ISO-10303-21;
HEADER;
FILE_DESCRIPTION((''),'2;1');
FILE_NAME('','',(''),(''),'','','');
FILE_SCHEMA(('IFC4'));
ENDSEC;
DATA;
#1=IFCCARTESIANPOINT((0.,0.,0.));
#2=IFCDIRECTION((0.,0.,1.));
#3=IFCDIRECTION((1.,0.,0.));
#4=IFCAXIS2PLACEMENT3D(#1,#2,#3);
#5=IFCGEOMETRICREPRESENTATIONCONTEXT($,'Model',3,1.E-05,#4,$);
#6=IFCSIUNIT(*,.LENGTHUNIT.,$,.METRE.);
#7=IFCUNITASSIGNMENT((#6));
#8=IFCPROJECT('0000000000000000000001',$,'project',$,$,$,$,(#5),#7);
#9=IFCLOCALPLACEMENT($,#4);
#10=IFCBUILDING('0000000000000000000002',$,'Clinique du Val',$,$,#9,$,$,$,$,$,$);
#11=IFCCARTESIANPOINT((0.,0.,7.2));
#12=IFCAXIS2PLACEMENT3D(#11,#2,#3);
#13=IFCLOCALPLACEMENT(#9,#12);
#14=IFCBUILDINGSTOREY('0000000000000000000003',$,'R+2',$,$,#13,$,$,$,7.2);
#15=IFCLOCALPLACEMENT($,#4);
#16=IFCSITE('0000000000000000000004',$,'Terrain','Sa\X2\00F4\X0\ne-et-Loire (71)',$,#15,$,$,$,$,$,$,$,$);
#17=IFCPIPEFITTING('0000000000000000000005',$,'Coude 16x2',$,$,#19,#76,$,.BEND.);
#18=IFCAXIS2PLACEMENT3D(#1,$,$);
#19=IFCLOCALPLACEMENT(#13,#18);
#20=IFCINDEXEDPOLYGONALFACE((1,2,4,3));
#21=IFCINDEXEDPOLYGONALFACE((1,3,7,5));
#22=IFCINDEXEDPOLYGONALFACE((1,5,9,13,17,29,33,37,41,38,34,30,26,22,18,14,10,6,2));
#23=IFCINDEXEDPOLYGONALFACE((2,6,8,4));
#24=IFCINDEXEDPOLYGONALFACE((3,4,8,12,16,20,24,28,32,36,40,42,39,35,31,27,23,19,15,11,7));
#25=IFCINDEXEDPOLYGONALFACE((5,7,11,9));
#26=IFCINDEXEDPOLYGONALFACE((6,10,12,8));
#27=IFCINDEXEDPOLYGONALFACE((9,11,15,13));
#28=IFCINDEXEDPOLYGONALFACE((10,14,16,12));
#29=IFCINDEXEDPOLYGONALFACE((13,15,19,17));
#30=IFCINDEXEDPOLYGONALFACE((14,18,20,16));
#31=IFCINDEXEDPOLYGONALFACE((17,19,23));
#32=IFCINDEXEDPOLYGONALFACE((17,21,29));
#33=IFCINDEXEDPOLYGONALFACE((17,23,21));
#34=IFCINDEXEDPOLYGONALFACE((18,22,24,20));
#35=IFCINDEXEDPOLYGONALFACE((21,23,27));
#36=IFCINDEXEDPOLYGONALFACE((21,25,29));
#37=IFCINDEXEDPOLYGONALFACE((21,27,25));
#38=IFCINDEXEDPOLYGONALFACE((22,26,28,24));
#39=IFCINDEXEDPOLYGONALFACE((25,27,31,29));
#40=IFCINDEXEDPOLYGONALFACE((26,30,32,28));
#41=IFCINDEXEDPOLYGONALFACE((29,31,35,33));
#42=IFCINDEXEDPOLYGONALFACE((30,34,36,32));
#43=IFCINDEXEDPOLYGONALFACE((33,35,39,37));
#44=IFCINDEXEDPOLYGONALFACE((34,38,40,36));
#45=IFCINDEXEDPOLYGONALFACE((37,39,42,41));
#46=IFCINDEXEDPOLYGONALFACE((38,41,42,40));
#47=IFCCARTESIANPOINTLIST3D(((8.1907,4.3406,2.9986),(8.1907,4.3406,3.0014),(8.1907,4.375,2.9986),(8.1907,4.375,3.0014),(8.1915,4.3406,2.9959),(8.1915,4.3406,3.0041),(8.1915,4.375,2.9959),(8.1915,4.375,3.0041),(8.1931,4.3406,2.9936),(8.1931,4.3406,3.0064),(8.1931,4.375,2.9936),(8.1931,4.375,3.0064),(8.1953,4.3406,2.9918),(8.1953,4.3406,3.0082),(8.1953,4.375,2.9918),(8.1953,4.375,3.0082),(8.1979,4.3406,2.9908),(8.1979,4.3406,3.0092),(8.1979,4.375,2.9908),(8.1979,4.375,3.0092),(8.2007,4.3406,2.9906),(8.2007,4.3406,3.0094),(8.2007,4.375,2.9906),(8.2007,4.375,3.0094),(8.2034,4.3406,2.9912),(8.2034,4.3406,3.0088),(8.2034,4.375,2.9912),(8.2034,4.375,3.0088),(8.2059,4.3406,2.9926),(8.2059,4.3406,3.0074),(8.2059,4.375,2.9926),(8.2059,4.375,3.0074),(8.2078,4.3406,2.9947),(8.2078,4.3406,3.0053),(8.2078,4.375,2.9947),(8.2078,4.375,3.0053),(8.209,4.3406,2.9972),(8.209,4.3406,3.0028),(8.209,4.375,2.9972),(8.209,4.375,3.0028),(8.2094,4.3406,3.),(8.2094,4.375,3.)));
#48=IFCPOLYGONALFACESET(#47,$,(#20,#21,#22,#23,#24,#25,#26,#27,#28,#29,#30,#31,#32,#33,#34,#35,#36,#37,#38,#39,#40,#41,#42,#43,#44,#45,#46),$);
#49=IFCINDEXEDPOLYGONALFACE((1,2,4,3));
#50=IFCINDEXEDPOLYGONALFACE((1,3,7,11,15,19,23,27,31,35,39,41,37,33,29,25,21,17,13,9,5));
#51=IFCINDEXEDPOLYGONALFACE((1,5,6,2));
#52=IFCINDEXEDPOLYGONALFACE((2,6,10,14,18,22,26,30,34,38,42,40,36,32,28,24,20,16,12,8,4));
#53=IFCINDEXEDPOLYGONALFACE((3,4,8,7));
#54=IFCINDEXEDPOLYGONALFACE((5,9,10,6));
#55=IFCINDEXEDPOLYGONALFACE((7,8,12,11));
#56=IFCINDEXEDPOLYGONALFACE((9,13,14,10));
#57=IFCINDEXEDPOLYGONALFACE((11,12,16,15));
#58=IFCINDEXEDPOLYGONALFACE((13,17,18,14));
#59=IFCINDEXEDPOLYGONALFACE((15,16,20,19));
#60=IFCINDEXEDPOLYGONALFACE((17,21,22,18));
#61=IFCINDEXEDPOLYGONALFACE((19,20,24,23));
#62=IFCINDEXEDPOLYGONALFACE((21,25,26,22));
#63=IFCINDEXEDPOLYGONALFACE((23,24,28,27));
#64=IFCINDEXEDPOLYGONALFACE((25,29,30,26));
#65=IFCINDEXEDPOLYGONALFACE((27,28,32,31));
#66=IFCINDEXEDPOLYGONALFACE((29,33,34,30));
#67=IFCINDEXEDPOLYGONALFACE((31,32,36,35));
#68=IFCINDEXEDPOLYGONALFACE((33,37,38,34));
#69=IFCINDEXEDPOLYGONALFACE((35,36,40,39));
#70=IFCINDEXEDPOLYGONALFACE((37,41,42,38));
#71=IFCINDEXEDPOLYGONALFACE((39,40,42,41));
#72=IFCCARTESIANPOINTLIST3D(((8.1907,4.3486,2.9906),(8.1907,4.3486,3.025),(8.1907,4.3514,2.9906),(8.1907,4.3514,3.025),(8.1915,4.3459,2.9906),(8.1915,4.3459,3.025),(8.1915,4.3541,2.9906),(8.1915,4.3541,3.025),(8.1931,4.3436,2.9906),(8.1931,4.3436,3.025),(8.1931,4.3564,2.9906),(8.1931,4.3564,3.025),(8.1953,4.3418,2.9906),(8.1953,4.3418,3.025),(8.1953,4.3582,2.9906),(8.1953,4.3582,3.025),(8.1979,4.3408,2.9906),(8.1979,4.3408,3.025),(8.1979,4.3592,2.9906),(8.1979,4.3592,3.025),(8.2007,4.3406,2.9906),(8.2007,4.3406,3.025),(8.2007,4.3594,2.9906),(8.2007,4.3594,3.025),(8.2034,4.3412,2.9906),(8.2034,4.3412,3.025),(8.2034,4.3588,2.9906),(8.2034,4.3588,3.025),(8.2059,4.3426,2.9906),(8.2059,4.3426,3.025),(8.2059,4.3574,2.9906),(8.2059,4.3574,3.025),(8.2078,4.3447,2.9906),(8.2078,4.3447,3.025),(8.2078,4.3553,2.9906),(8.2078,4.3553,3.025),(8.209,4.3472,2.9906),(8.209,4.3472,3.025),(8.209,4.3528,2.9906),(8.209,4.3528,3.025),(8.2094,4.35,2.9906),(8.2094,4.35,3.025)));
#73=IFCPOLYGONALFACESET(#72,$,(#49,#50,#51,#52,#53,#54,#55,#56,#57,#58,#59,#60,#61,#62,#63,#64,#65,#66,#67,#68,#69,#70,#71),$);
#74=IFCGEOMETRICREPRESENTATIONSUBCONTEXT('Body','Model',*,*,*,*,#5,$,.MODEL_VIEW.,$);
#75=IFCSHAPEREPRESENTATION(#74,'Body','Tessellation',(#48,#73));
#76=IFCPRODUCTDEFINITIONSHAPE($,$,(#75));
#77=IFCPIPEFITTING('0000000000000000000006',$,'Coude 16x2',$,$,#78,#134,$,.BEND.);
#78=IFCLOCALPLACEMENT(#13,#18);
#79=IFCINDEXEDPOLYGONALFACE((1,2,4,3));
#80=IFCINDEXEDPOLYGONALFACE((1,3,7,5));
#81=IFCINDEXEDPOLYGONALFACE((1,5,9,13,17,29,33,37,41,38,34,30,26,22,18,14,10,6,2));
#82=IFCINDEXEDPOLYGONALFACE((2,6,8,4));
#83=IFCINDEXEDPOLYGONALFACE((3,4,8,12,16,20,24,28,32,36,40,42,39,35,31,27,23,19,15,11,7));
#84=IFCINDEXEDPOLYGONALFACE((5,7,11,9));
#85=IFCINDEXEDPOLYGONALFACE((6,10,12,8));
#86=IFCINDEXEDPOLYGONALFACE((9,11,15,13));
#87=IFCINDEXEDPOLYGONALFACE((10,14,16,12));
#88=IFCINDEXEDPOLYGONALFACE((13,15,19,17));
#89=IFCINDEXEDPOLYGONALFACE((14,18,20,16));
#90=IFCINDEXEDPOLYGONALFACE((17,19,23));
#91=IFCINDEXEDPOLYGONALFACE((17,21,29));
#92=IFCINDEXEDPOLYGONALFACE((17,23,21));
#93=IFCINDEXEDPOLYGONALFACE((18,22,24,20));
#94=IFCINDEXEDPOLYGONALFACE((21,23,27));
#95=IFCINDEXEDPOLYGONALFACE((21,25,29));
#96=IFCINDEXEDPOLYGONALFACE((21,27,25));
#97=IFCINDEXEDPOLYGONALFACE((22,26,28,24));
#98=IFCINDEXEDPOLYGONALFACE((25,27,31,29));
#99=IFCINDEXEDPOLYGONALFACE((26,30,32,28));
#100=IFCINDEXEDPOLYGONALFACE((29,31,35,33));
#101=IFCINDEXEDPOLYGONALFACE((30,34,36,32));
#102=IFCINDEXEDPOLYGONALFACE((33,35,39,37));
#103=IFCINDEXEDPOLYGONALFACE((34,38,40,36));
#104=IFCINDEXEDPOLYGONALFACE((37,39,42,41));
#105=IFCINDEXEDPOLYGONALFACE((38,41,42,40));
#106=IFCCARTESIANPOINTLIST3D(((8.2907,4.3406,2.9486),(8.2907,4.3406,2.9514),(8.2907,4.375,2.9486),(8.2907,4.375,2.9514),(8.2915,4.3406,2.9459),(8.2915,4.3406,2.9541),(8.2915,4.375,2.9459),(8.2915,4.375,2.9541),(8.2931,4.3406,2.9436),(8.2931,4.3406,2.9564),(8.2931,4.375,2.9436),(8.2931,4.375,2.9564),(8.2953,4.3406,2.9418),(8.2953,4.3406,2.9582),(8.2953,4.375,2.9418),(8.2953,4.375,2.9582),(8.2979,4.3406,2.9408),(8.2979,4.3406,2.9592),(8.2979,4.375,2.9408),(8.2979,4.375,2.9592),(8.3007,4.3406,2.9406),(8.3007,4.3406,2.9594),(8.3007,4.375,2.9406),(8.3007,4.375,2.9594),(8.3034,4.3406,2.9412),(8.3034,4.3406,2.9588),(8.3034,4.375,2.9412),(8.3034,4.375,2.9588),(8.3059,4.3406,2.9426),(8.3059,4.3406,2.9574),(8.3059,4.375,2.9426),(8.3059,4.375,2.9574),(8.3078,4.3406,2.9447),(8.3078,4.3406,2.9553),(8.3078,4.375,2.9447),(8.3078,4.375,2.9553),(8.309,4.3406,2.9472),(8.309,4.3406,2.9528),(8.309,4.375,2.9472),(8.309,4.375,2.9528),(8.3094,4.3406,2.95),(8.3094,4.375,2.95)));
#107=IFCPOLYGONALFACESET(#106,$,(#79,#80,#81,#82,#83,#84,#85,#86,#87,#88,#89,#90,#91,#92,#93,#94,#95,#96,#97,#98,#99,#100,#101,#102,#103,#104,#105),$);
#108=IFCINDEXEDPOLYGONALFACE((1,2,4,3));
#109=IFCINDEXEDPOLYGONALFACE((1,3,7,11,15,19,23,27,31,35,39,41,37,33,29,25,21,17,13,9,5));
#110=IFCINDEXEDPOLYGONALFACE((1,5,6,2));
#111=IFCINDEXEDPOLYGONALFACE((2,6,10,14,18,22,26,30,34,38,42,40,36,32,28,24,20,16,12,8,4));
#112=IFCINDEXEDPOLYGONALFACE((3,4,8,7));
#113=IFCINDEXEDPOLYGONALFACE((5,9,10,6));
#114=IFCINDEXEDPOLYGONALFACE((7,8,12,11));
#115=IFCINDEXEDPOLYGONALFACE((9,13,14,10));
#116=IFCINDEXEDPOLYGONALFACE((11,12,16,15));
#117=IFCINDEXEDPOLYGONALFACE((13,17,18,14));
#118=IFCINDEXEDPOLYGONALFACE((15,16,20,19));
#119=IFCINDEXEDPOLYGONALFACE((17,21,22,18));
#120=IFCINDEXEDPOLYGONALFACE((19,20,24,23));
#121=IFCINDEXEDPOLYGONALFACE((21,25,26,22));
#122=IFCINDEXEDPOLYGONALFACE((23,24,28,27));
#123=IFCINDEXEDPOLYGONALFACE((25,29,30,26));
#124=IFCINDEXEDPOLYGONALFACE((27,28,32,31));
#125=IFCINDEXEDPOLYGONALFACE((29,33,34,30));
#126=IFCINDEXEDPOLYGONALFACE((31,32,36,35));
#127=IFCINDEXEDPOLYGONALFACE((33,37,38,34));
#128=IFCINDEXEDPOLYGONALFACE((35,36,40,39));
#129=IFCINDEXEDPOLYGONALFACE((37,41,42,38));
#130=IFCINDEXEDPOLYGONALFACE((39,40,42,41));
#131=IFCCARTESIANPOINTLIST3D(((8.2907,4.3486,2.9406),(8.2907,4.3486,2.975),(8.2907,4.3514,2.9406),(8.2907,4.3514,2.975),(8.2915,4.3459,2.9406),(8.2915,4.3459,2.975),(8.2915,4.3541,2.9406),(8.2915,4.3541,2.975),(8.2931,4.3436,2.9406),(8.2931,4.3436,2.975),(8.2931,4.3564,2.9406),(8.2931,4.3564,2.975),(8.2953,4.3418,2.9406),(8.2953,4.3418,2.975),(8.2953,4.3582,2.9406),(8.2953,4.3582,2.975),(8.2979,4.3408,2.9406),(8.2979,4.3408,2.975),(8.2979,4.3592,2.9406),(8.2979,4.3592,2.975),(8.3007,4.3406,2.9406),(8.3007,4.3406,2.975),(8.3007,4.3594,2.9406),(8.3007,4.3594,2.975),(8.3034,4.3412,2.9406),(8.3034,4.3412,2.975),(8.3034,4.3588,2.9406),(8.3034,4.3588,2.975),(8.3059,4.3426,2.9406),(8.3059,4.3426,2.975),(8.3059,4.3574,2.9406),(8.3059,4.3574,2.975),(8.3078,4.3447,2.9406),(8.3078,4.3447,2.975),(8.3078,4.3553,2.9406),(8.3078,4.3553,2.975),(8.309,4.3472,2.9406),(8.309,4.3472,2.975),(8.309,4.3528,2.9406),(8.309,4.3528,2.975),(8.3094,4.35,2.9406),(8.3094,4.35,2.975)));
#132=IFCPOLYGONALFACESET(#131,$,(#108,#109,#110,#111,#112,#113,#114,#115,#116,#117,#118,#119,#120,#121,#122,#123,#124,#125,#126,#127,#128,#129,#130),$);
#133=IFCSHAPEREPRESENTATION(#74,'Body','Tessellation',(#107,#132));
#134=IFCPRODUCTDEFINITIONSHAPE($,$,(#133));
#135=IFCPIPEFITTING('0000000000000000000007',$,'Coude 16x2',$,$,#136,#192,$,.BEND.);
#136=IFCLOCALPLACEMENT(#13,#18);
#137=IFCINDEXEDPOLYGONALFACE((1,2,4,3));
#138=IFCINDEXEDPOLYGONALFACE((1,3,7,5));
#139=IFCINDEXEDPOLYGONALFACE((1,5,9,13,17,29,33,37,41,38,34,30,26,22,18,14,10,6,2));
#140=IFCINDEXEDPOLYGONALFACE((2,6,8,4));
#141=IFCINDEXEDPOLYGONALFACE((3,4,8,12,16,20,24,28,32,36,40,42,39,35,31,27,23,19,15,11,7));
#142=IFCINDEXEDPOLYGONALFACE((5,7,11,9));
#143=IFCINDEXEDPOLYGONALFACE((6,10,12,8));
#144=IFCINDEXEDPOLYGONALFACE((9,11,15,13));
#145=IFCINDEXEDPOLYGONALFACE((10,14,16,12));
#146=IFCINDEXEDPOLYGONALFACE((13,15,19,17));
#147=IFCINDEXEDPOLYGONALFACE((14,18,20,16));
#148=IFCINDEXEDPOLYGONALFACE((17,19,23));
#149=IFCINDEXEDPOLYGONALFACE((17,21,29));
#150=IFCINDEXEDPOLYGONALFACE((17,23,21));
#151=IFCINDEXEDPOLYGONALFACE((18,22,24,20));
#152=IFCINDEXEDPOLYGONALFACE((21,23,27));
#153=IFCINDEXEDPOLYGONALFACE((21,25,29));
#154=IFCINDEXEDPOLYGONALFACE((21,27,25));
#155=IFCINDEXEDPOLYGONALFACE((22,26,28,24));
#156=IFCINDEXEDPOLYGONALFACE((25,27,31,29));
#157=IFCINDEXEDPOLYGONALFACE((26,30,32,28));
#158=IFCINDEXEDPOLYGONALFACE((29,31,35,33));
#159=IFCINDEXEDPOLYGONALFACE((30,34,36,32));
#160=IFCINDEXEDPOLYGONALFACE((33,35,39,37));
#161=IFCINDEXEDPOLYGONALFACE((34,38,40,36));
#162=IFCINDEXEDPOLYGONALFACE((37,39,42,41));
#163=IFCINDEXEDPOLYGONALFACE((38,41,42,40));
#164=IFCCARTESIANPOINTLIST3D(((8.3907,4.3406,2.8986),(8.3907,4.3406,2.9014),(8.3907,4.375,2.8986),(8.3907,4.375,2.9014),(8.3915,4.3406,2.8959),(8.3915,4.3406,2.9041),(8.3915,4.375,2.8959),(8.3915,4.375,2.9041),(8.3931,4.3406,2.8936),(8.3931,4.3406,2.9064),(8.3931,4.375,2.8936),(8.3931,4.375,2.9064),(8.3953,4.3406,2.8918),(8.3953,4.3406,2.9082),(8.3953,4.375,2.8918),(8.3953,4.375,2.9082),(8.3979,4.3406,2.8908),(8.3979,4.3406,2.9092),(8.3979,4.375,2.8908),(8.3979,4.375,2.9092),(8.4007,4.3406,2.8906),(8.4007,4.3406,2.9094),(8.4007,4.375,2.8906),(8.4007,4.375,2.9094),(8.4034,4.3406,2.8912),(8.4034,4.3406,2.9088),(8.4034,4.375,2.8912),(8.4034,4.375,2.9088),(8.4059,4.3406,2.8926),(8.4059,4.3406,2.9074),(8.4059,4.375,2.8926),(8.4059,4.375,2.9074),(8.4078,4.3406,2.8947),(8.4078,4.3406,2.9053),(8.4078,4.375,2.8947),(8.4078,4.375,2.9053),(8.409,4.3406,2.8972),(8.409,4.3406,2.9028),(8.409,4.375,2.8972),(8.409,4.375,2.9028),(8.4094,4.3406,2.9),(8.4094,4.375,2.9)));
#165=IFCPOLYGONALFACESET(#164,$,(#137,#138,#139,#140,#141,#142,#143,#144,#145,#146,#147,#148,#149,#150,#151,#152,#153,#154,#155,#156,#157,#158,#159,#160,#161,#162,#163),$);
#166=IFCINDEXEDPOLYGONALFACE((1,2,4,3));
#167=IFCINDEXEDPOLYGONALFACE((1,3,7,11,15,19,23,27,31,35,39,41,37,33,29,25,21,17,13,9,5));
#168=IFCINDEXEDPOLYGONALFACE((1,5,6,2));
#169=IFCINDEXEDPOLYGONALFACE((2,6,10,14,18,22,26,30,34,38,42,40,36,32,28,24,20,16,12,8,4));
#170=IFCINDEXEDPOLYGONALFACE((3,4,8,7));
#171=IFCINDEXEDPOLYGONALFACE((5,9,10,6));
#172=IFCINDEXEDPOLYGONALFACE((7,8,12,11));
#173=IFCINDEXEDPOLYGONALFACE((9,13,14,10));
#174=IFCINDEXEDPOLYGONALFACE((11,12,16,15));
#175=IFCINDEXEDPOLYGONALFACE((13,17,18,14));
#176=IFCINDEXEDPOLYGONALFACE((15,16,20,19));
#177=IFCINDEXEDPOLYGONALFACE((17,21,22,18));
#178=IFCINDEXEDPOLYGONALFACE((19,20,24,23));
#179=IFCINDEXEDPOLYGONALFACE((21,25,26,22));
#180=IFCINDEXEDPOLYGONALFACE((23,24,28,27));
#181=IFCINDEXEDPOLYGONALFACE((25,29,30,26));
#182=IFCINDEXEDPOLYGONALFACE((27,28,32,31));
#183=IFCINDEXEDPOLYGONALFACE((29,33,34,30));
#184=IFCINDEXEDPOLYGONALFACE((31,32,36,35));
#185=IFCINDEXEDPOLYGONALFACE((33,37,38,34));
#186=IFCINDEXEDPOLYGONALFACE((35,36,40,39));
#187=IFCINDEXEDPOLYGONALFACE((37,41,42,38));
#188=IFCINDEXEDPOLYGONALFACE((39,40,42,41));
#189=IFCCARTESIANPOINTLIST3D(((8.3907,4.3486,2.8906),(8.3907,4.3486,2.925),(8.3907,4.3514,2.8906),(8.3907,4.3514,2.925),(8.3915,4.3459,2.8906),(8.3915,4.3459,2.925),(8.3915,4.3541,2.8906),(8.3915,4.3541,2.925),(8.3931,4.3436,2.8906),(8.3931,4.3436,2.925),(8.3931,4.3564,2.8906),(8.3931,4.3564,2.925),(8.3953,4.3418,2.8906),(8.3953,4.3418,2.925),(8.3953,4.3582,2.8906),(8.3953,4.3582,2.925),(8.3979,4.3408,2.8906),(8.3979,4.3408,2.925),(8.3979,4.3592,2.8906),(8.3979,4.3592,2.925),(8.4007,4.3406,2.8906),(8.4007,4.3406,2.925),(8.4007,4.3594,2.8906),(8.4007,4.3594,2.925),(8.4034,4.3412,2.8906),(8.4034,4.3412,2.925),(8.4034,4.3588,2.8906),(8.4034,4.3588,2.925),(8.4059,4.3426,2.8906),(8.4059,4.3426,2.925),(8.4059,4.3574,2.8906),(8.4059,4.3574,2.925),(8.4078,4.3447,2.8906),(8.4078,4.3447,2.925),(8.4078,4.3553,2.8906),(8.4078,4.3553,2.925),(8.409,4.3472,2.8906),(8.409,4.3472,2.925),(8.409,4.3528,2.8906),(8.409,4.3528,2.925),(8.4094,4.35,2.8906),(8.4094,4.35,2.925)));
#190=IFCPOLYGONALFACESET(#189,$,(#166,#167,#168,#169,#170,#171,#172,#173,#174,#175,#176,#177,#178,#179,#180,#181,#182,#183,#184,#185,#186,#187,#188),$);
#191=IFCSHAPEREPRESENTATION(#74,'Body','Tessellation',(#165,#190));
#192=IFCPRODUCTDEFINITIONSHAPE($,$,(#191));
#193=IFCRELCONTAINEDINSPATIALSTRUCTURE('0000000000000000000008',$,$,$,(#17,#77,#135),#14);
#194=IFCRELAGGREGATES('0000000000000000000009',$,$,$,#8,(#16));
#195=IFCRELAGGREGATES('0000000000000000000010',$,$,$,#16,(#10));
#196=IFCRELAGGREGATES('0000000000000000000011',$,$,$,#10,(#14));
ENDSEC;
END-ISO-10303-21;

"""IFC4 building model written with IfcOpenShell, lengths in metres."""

from ifc_helpers import new_model, si_unit, frame, origin_with_axes, place, context, subcontext, project, spatial, circle, extrude, element, save


model = new_model("IFC4")

# Units and contexts
model_context = context("Model", 3, precision=1e-05, world=origin_with_axes())
body_context = subcontext(model_context, "Body", "Model", "MODEL_VIEW")
ifc_project = project(units=[si_unit("LENGTHUNIT", "METRE")], contexts=[model_context])

# Site, building, storey
site_placement = place(None, origin_with_axes())
site = spatial("IfcSite", under=ifc_project, at=site_placement, Name="Terrain", Description="Saône-et-Loire (71)")
building_placement = place(None, origin_with_axes())
building = spatial("IfcBuilding", under=site, at=building_placement, Name="Clinique du Val")
storey_placement = place(building_placement, frame((0.0, 0.0, 7.2), z_axis=(0.0, 0.0, 1.0), x_axis=(1.0, 0.0, 0.0)))
storey = spatial("IfcBuildingStorey", under=building, at=storey_placement, Name="R+2", Elevation=7.2)

# Pipe fittings
for number, where, z_axis, x_axis, name in (
    (1, (8.2, 4.35, 3.0), (0.0, 0.0, 1.0), (1.0, 0.0, 0.0), "Coude 16x2"),
    (2, (8.3, 4.35, 2.95), (0.0, 0.0, 1.0), (1.0, 0.0, 0.0), "Coude 16x2"),
    (3, (8.4, 4.35, 2.9), (0.0, 0.0, 1.0), (1.0, 0.0, 0.0), "Coude 16x2"),
):
    element("IfcPipeFitting", number, at=place(storey_placement, frame(where, z_axis=z_axis, x_axis=x_axis)), inside=storey, Name=name, PredefinedType="BEND", context=body_context, shape_type="SweptSolid", body=[
        extrude(circle(Radius=0.0094), frame((0.0, -0.0094, 0.0), z_axis=(0.0, 1.0, 0.0), x_axis=(1.0, 0.0, 0.0)), (0.0, 0.0, 1.0), 0.0344),
        extrude(circle(Radius=0.0094), frame((0.0, 0.0, -0.0094), z_axis=(0.0, 0.0, 1.0), x_axis=(1.0, 0.0, 0.0)), (0.0, 0.0, 1.0), 0.0344),
    ])

save(model, "model.ifc")
